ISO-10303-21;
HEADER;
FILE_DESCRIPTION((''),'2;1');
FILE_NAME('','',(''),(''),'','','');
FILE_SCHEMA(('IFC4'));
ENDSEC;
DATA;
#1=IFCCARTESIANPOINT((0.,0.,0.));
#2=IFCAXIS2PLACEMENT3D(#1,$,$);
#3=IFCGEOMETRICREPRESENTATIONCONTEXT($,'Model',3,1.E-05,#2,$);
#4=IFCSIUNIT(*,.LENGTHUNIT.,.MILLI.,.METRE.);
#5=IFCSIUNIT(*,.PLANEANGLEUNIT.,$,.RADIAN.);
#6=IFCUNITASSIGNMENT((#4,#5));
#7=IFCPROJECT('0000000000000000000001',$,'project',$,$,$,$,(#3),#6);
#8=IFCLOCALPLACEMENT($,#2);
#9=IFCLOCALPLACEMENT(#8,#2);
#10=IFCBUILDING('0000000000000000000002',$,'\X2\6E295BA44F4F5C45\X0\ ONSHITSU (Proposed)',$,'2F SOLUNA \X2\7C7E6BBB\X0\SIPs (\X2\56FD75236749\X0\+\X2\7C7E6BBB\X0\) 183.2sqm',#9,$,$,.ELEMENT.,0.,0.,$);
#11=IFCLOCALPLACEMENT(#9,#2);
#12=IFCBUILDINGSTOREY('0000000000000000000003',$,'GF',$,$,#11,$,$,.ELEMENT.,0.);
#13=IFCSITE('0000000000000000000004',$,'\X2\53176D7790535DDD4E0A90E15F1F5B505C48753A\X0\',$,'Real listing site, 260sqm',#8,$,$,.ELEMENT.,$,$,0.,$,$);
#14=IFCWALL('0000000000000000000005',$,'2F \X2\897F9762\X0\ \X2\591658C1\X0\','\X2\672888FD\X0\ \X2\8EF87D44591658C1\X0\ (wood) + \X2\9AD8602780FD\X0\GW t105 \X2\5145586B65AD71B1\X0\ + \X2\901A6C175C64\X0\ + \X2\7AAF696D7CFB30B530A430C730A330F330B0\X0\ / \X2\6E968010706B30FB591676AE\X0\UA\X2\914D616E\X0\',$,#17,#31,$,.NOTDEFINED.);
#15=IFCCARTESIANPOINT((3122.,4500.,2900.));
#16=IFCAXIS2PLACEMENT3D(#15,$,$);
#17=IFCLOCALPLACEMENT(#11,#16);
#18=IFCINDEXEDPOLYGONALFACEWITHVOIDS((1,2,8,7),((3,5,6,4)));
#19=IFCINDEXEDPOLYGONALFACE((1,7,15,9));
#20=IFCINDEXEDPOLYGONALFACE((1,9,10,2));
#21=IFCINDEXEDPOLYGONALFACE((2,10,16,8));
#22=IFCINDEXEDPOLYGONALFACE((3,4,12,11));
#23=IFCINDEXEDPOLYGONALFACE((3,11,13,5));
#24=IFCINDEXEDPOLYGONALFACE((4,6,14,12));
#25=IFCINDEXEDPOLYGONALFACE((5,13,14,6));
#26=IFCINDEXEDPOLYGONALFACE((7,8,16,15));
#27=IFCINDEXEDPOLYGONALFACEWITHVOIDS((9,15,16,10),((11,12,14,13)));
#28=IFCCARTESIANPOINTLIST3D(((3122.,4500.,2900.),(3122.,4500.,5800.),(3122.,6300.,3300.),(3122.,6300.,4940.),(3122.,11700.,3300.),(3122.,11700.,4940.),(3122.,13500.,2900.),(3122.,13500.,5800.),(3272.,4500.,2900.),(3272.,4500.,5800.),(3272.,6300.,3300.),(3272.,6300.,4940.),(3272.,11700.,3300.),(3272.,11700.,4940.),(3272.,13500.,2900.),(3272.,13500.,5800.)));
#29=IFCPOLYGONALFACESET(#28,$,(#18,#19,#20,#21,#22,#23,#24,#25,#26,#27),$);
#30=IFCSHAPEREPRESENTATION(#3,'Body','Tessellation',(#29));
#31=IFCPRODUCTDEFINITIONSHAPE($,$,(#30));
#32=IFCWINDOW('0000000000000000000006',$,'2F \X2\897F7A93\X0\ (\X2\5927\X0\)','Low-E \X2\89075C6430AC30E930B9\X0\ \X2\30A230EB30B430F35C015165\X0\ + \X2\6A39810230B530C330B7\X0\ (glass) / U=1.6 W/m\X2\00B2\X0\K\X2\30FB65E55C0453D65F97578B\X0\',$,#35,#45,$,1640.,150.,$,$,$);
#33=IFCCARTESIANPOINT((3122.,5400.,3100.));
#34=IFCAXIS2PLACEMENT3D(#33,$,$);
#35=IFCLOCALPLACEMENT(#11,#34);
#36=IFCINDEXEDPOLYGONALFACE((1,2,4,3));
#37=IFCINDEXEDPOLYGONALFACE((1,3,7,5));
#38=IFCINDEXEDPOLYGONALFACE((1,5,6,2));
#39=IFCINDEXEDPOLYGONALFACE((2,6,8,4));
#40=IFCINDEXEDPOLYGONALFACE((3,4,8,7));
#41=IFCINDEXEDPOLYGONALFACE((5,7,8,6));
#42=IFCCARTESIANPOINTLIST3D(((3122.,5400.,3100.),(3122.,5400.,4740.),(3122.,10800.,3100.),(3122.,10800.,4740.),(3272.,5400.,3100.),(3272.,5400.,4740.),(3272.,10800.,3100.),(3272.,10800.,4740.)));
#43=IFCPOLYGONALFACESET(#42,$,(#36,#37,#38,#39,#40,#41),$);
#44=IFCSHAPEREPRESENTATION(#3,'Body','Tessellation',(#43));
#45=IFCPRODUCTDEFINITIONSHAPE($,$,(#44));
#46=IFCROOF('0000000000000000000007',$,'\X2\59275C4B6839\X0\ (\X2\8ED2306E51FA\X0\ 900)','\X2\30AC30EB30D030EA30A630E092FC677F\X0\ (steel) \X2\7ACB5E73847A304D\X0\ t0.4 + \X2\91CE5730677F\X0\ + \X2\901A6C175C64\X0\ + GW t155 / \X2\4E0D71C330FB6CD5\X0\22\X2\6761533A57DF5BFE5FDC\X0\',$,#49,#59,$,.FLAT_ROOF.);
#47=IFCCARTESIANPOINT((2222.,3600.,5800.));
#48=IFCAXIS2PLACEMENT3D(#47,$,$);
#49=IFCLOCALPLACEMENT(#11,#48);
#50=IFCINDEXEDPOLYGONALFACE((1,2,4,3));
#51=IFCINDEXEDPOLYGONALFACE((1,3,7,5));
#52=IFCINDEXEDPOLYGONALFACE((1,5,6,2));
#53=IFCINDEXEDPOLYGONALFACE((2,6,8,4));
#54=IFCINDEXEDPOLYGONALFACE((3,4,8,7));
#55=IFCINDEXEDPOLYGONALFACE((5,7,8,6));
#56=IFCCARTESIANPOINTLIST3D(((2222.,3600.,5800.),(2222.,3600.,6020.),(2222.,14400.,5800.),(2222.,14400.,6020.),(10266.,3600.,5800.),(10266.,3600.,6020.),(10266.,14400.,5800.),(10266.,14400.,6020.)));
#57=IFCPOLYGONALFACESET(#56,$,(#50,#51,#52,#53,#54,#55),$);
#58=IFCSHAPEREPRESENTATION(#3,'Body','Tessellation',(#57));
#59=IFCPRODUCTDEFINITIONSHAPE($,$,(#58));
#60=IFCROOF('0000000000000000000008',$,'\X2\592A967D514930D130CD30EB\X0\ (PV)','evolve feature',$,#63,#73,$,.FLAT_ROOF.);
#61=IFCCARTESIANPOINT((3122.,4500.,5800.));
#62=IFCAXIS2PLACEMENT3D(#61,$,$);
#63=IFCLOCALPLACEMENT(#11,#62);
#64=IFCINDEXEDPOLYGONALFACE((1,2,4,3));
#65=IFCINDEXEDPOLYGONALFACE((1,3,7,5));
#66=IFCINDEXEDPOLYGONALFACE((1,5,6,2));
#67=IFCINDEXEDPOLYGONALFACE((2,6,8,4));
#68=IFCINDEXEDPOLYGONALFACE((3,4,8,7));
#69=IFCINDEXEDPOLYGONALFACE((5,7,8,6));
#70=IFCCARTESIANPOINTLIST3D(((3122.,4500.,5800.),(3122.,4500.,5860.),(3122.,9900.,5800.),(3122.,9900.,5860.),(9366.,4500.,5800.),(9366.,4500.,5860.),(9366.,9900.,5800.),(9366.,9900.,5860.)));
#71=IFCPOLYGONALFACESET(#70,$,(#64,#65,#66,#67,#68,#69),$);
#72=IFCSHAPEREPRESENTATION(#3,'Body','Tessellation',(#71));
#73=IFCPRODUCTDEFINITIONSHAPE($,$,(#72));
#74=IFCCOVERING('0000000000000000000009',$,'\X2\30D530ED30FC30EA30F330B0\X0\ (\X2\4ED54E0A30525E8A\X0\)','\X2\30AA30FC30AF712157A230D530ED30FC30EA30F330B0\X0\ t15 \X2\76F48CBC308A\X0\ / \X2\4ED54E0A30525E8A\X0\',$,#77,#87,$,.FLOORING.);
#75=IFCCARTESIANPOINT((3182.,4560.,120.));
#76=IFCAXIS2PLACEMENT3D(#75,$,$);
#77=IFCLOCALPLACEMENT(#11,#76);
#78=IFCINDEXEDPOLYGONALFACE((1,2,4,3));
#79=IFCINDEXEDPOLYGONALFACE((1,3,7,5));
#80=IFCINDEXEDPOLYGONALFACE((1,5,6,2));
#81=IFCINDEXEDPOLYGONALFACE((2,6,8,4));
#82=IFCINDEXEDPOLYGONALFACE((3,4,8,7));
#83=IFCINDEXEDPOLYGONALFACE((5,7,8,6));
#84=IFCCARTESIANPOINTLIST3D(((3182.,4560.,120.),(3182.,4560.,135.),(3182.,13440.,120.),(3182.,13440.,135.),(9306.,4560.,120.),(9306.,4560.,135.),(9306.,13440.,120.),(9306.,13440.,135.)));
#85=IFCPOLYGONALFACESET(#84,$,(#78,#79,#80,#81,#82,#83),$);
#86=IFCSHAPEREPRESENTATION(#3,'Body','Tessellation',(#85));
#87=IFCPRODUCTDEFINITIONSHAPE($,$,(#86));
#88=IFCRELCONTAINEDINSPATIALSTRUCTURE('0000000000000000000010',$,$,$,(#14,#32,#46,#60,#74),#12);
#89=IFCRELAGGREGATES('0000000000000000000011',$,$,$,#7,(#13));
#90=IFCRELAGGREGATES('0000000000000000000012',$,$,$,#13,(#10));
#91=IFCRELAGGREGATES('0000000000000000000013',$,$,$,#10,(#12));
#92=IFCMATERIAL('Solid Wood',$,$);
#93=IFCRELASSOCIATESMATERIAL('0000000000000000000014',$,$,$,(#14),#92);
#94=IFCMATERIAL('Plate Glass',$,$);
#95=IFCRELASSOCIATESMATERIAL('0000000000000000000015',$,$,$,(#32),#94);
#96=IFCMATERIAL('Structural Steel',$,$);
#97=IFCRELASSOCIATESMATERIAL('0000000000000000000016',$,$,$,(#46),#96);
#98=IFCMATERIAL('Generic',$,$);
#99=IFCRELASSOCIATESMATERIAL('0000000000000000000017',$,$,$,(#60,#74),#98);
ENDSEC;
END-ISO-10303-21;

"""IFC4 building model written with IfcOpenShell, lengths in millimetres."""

from ifc_helpers import new_model, si_unit, frame, frame_2d, origin, place, context, project, spatial, rectangle, extrude, material, element, fill, save


model = new_model("IFC4")

# Units and contexts
model_context = context("Model", 3, precision=1e-05, world=origin())
ifc_project = project(units=[si_unit("LENGTHUNIT", "METRE", prefix="MILLI"), si_unit("PLANEANGLEUNIT", "RADIAN")], contexts=[model_context])

# Site, building, storey
site_placement = place(None, origin())
site = spatial("IfcSite", under=ifc_project, at=site_placement, Name="北海道川上郡弟子屈町", ObjectType="Real listing site, 260sqm", CompositionType="ELEMENT", RefElevation=0.0)
building_placement = place(site_placement, origin())
building = spatial("IfcBuilding", under=site, at=building_placement, Name="温室住居 ONSHITSU (Proposed)", ObjectType="2F SOLUNA 籾殻SIPs (国産杉+籾殻) 183.2sqm", CompositionType="ELEMENT", ElevationOfRefHeight=0.0, ElevationOfTerrain=0.0)
storey_placement = place(building_placement, origin())
storey = spatial("IfcBuildingStorey", under=building, at=storey_placement, Name="GF", CompositionType="ELEMENT", Elevation=0.0)

# Shared definitions
ifc_material_1 = material(Name="Solid Wood")
ifc_material_2 = material(Name="Generic")

# Shared definitions
ifc_material_3 = material(Name="Plate Glass")

# Wall, opening, window
wall_1_placement = place(storey_placement, frame((3122.0, 4500.0, 2900.0)))
wall_1 = element("IfcWall", 1, at=wall_1_placement, inside=storey, material=ifc_material_1, Name="2F 西面 外壁", Description="木製 軸組外壁 (wood) + 高性能GW t105 充填断熱 + 通気層 + 窯業系サイディング / 準耐火・外皮UA配慮", PredefinedType="NOTDEFINED", context=model_context, shape_type="SweptSolid", body=[
    extrude(rectangle(XDim=150.0, YDim=9000.0, at=frame_2d((75.0, 4500.0))), frame((3122.0, 4500.0, 2900.0)), (0.0, 0.0, 1.0), 2900.0),
])
opening_1_placement = place(storey_placement, frame((3122.0, 5400.0, 3100.0)))
opening_1 = element("IfcOpeningElement", 2, at=opening_1_placement, cuts=wall_1, PredefinedType="NOTDEFINED", context=model_context, shape_type="SweptSolid", body=[
    extrude(rectangle(XDim=150.0, YDim=5400.0, at=frame_2d((75.0, 2700.0))), frame((3122.0, 5400.0, 3100.0)), (0.0, 0.0, 1.0), 1640.0),
])
window_1_placement = place(storey_placement, frame((3122.0, 5400.0, 3100.0)))
window_1 = element("IfcWindow", 3, at=window_1_placement, inside=storey, material=ifc_material_3, Name="2F 西窓 (大)", Description="Low-E 複層ガラス アルゴン封入 + 樹脂サッシ (glass) / U=1.6 W/m²K・日射取得型", OverallHeight=1640.0, OverallWidth=150.0, context=model_context, shape_type="SweptSolid", body=[
    extrude(rectangle(XDim=150.0, YDim=5400.0, at=frame_2d((75.0, 2700.0))), frame((3122.0, 5400.0, 3100.0)), (0.0, 0.0, 1.0), 1640.0),
])
fill(opening_1, window_1)

# Roofs
ifc_material_4 = material(Name="Structural Steel")
roof_1_placement = place(storey_placement, frame((2222.0, 3600.0, 5800.0)))
element("IfcRoof", 4, at=roof_1_placement, inside=storey, material=ifc_material_4, Name="大屋根 (軒の出 900)", Description="ガルバリウム鋼板 (steel) 立平葺き t0.4 + 野地板 + 通気層 + GW t155 / 不燃・法22条区域対応", PredefinedType="FLAT_ROOF", context=model_context, shape_type="SweptSolid", body=[
    extrude(rectangle(XDim=8044.0, YDim=10800.0, at=frame_2d((4022.0, 5400.0))), frame((2222.0, 3600.0, 5800.0)), (0.0, 0.0, 1.0), 220.0),
])
roof_2_placement = place(storey_placement, frame((3122.0, 4500.0, 5800.0)))
element("IfcRoof", 5, at=roof_2_placement, inside=storey, material=ifc_material_2, Name="太陽光パネル (PV)", Description="evolve feature", PredefinedType="FLAT_ROOF", context=model_context, shape_type="SweptSolid", body=[
    extrude(rectangle(XDim=6244.0, YDim=5400.0, at=frame_2d((3122.0, 2700.0))), frame((3122.0, 4500.0, 5800.0)), (0.0, 0.0, 1.0), 60.0),
])

# Covering
covering_placement = place(storey_placement, frame((3182.0, 4560.0, 120.0)))
element("IfcCovering", 6, at=covering_placement, inside=storey, material=ifc_material_2, Name="フローリング (仕上げ床)", Description="オーク無垢フローリング t15 直貼り / 仕上げ床", PredefinedType="FLOORING", context=model_context, shape_type="SweptSolid", body=[
    extrude(rectangle(XDim=6124.0, YDim=8880.0, at=frame_2d((3062.0, 4440.0))), frame((3182.0, 4560.0, 120.0)), (0.0, 0.0, 1.0), 15.0),
])

save(model, "model.ifc")
